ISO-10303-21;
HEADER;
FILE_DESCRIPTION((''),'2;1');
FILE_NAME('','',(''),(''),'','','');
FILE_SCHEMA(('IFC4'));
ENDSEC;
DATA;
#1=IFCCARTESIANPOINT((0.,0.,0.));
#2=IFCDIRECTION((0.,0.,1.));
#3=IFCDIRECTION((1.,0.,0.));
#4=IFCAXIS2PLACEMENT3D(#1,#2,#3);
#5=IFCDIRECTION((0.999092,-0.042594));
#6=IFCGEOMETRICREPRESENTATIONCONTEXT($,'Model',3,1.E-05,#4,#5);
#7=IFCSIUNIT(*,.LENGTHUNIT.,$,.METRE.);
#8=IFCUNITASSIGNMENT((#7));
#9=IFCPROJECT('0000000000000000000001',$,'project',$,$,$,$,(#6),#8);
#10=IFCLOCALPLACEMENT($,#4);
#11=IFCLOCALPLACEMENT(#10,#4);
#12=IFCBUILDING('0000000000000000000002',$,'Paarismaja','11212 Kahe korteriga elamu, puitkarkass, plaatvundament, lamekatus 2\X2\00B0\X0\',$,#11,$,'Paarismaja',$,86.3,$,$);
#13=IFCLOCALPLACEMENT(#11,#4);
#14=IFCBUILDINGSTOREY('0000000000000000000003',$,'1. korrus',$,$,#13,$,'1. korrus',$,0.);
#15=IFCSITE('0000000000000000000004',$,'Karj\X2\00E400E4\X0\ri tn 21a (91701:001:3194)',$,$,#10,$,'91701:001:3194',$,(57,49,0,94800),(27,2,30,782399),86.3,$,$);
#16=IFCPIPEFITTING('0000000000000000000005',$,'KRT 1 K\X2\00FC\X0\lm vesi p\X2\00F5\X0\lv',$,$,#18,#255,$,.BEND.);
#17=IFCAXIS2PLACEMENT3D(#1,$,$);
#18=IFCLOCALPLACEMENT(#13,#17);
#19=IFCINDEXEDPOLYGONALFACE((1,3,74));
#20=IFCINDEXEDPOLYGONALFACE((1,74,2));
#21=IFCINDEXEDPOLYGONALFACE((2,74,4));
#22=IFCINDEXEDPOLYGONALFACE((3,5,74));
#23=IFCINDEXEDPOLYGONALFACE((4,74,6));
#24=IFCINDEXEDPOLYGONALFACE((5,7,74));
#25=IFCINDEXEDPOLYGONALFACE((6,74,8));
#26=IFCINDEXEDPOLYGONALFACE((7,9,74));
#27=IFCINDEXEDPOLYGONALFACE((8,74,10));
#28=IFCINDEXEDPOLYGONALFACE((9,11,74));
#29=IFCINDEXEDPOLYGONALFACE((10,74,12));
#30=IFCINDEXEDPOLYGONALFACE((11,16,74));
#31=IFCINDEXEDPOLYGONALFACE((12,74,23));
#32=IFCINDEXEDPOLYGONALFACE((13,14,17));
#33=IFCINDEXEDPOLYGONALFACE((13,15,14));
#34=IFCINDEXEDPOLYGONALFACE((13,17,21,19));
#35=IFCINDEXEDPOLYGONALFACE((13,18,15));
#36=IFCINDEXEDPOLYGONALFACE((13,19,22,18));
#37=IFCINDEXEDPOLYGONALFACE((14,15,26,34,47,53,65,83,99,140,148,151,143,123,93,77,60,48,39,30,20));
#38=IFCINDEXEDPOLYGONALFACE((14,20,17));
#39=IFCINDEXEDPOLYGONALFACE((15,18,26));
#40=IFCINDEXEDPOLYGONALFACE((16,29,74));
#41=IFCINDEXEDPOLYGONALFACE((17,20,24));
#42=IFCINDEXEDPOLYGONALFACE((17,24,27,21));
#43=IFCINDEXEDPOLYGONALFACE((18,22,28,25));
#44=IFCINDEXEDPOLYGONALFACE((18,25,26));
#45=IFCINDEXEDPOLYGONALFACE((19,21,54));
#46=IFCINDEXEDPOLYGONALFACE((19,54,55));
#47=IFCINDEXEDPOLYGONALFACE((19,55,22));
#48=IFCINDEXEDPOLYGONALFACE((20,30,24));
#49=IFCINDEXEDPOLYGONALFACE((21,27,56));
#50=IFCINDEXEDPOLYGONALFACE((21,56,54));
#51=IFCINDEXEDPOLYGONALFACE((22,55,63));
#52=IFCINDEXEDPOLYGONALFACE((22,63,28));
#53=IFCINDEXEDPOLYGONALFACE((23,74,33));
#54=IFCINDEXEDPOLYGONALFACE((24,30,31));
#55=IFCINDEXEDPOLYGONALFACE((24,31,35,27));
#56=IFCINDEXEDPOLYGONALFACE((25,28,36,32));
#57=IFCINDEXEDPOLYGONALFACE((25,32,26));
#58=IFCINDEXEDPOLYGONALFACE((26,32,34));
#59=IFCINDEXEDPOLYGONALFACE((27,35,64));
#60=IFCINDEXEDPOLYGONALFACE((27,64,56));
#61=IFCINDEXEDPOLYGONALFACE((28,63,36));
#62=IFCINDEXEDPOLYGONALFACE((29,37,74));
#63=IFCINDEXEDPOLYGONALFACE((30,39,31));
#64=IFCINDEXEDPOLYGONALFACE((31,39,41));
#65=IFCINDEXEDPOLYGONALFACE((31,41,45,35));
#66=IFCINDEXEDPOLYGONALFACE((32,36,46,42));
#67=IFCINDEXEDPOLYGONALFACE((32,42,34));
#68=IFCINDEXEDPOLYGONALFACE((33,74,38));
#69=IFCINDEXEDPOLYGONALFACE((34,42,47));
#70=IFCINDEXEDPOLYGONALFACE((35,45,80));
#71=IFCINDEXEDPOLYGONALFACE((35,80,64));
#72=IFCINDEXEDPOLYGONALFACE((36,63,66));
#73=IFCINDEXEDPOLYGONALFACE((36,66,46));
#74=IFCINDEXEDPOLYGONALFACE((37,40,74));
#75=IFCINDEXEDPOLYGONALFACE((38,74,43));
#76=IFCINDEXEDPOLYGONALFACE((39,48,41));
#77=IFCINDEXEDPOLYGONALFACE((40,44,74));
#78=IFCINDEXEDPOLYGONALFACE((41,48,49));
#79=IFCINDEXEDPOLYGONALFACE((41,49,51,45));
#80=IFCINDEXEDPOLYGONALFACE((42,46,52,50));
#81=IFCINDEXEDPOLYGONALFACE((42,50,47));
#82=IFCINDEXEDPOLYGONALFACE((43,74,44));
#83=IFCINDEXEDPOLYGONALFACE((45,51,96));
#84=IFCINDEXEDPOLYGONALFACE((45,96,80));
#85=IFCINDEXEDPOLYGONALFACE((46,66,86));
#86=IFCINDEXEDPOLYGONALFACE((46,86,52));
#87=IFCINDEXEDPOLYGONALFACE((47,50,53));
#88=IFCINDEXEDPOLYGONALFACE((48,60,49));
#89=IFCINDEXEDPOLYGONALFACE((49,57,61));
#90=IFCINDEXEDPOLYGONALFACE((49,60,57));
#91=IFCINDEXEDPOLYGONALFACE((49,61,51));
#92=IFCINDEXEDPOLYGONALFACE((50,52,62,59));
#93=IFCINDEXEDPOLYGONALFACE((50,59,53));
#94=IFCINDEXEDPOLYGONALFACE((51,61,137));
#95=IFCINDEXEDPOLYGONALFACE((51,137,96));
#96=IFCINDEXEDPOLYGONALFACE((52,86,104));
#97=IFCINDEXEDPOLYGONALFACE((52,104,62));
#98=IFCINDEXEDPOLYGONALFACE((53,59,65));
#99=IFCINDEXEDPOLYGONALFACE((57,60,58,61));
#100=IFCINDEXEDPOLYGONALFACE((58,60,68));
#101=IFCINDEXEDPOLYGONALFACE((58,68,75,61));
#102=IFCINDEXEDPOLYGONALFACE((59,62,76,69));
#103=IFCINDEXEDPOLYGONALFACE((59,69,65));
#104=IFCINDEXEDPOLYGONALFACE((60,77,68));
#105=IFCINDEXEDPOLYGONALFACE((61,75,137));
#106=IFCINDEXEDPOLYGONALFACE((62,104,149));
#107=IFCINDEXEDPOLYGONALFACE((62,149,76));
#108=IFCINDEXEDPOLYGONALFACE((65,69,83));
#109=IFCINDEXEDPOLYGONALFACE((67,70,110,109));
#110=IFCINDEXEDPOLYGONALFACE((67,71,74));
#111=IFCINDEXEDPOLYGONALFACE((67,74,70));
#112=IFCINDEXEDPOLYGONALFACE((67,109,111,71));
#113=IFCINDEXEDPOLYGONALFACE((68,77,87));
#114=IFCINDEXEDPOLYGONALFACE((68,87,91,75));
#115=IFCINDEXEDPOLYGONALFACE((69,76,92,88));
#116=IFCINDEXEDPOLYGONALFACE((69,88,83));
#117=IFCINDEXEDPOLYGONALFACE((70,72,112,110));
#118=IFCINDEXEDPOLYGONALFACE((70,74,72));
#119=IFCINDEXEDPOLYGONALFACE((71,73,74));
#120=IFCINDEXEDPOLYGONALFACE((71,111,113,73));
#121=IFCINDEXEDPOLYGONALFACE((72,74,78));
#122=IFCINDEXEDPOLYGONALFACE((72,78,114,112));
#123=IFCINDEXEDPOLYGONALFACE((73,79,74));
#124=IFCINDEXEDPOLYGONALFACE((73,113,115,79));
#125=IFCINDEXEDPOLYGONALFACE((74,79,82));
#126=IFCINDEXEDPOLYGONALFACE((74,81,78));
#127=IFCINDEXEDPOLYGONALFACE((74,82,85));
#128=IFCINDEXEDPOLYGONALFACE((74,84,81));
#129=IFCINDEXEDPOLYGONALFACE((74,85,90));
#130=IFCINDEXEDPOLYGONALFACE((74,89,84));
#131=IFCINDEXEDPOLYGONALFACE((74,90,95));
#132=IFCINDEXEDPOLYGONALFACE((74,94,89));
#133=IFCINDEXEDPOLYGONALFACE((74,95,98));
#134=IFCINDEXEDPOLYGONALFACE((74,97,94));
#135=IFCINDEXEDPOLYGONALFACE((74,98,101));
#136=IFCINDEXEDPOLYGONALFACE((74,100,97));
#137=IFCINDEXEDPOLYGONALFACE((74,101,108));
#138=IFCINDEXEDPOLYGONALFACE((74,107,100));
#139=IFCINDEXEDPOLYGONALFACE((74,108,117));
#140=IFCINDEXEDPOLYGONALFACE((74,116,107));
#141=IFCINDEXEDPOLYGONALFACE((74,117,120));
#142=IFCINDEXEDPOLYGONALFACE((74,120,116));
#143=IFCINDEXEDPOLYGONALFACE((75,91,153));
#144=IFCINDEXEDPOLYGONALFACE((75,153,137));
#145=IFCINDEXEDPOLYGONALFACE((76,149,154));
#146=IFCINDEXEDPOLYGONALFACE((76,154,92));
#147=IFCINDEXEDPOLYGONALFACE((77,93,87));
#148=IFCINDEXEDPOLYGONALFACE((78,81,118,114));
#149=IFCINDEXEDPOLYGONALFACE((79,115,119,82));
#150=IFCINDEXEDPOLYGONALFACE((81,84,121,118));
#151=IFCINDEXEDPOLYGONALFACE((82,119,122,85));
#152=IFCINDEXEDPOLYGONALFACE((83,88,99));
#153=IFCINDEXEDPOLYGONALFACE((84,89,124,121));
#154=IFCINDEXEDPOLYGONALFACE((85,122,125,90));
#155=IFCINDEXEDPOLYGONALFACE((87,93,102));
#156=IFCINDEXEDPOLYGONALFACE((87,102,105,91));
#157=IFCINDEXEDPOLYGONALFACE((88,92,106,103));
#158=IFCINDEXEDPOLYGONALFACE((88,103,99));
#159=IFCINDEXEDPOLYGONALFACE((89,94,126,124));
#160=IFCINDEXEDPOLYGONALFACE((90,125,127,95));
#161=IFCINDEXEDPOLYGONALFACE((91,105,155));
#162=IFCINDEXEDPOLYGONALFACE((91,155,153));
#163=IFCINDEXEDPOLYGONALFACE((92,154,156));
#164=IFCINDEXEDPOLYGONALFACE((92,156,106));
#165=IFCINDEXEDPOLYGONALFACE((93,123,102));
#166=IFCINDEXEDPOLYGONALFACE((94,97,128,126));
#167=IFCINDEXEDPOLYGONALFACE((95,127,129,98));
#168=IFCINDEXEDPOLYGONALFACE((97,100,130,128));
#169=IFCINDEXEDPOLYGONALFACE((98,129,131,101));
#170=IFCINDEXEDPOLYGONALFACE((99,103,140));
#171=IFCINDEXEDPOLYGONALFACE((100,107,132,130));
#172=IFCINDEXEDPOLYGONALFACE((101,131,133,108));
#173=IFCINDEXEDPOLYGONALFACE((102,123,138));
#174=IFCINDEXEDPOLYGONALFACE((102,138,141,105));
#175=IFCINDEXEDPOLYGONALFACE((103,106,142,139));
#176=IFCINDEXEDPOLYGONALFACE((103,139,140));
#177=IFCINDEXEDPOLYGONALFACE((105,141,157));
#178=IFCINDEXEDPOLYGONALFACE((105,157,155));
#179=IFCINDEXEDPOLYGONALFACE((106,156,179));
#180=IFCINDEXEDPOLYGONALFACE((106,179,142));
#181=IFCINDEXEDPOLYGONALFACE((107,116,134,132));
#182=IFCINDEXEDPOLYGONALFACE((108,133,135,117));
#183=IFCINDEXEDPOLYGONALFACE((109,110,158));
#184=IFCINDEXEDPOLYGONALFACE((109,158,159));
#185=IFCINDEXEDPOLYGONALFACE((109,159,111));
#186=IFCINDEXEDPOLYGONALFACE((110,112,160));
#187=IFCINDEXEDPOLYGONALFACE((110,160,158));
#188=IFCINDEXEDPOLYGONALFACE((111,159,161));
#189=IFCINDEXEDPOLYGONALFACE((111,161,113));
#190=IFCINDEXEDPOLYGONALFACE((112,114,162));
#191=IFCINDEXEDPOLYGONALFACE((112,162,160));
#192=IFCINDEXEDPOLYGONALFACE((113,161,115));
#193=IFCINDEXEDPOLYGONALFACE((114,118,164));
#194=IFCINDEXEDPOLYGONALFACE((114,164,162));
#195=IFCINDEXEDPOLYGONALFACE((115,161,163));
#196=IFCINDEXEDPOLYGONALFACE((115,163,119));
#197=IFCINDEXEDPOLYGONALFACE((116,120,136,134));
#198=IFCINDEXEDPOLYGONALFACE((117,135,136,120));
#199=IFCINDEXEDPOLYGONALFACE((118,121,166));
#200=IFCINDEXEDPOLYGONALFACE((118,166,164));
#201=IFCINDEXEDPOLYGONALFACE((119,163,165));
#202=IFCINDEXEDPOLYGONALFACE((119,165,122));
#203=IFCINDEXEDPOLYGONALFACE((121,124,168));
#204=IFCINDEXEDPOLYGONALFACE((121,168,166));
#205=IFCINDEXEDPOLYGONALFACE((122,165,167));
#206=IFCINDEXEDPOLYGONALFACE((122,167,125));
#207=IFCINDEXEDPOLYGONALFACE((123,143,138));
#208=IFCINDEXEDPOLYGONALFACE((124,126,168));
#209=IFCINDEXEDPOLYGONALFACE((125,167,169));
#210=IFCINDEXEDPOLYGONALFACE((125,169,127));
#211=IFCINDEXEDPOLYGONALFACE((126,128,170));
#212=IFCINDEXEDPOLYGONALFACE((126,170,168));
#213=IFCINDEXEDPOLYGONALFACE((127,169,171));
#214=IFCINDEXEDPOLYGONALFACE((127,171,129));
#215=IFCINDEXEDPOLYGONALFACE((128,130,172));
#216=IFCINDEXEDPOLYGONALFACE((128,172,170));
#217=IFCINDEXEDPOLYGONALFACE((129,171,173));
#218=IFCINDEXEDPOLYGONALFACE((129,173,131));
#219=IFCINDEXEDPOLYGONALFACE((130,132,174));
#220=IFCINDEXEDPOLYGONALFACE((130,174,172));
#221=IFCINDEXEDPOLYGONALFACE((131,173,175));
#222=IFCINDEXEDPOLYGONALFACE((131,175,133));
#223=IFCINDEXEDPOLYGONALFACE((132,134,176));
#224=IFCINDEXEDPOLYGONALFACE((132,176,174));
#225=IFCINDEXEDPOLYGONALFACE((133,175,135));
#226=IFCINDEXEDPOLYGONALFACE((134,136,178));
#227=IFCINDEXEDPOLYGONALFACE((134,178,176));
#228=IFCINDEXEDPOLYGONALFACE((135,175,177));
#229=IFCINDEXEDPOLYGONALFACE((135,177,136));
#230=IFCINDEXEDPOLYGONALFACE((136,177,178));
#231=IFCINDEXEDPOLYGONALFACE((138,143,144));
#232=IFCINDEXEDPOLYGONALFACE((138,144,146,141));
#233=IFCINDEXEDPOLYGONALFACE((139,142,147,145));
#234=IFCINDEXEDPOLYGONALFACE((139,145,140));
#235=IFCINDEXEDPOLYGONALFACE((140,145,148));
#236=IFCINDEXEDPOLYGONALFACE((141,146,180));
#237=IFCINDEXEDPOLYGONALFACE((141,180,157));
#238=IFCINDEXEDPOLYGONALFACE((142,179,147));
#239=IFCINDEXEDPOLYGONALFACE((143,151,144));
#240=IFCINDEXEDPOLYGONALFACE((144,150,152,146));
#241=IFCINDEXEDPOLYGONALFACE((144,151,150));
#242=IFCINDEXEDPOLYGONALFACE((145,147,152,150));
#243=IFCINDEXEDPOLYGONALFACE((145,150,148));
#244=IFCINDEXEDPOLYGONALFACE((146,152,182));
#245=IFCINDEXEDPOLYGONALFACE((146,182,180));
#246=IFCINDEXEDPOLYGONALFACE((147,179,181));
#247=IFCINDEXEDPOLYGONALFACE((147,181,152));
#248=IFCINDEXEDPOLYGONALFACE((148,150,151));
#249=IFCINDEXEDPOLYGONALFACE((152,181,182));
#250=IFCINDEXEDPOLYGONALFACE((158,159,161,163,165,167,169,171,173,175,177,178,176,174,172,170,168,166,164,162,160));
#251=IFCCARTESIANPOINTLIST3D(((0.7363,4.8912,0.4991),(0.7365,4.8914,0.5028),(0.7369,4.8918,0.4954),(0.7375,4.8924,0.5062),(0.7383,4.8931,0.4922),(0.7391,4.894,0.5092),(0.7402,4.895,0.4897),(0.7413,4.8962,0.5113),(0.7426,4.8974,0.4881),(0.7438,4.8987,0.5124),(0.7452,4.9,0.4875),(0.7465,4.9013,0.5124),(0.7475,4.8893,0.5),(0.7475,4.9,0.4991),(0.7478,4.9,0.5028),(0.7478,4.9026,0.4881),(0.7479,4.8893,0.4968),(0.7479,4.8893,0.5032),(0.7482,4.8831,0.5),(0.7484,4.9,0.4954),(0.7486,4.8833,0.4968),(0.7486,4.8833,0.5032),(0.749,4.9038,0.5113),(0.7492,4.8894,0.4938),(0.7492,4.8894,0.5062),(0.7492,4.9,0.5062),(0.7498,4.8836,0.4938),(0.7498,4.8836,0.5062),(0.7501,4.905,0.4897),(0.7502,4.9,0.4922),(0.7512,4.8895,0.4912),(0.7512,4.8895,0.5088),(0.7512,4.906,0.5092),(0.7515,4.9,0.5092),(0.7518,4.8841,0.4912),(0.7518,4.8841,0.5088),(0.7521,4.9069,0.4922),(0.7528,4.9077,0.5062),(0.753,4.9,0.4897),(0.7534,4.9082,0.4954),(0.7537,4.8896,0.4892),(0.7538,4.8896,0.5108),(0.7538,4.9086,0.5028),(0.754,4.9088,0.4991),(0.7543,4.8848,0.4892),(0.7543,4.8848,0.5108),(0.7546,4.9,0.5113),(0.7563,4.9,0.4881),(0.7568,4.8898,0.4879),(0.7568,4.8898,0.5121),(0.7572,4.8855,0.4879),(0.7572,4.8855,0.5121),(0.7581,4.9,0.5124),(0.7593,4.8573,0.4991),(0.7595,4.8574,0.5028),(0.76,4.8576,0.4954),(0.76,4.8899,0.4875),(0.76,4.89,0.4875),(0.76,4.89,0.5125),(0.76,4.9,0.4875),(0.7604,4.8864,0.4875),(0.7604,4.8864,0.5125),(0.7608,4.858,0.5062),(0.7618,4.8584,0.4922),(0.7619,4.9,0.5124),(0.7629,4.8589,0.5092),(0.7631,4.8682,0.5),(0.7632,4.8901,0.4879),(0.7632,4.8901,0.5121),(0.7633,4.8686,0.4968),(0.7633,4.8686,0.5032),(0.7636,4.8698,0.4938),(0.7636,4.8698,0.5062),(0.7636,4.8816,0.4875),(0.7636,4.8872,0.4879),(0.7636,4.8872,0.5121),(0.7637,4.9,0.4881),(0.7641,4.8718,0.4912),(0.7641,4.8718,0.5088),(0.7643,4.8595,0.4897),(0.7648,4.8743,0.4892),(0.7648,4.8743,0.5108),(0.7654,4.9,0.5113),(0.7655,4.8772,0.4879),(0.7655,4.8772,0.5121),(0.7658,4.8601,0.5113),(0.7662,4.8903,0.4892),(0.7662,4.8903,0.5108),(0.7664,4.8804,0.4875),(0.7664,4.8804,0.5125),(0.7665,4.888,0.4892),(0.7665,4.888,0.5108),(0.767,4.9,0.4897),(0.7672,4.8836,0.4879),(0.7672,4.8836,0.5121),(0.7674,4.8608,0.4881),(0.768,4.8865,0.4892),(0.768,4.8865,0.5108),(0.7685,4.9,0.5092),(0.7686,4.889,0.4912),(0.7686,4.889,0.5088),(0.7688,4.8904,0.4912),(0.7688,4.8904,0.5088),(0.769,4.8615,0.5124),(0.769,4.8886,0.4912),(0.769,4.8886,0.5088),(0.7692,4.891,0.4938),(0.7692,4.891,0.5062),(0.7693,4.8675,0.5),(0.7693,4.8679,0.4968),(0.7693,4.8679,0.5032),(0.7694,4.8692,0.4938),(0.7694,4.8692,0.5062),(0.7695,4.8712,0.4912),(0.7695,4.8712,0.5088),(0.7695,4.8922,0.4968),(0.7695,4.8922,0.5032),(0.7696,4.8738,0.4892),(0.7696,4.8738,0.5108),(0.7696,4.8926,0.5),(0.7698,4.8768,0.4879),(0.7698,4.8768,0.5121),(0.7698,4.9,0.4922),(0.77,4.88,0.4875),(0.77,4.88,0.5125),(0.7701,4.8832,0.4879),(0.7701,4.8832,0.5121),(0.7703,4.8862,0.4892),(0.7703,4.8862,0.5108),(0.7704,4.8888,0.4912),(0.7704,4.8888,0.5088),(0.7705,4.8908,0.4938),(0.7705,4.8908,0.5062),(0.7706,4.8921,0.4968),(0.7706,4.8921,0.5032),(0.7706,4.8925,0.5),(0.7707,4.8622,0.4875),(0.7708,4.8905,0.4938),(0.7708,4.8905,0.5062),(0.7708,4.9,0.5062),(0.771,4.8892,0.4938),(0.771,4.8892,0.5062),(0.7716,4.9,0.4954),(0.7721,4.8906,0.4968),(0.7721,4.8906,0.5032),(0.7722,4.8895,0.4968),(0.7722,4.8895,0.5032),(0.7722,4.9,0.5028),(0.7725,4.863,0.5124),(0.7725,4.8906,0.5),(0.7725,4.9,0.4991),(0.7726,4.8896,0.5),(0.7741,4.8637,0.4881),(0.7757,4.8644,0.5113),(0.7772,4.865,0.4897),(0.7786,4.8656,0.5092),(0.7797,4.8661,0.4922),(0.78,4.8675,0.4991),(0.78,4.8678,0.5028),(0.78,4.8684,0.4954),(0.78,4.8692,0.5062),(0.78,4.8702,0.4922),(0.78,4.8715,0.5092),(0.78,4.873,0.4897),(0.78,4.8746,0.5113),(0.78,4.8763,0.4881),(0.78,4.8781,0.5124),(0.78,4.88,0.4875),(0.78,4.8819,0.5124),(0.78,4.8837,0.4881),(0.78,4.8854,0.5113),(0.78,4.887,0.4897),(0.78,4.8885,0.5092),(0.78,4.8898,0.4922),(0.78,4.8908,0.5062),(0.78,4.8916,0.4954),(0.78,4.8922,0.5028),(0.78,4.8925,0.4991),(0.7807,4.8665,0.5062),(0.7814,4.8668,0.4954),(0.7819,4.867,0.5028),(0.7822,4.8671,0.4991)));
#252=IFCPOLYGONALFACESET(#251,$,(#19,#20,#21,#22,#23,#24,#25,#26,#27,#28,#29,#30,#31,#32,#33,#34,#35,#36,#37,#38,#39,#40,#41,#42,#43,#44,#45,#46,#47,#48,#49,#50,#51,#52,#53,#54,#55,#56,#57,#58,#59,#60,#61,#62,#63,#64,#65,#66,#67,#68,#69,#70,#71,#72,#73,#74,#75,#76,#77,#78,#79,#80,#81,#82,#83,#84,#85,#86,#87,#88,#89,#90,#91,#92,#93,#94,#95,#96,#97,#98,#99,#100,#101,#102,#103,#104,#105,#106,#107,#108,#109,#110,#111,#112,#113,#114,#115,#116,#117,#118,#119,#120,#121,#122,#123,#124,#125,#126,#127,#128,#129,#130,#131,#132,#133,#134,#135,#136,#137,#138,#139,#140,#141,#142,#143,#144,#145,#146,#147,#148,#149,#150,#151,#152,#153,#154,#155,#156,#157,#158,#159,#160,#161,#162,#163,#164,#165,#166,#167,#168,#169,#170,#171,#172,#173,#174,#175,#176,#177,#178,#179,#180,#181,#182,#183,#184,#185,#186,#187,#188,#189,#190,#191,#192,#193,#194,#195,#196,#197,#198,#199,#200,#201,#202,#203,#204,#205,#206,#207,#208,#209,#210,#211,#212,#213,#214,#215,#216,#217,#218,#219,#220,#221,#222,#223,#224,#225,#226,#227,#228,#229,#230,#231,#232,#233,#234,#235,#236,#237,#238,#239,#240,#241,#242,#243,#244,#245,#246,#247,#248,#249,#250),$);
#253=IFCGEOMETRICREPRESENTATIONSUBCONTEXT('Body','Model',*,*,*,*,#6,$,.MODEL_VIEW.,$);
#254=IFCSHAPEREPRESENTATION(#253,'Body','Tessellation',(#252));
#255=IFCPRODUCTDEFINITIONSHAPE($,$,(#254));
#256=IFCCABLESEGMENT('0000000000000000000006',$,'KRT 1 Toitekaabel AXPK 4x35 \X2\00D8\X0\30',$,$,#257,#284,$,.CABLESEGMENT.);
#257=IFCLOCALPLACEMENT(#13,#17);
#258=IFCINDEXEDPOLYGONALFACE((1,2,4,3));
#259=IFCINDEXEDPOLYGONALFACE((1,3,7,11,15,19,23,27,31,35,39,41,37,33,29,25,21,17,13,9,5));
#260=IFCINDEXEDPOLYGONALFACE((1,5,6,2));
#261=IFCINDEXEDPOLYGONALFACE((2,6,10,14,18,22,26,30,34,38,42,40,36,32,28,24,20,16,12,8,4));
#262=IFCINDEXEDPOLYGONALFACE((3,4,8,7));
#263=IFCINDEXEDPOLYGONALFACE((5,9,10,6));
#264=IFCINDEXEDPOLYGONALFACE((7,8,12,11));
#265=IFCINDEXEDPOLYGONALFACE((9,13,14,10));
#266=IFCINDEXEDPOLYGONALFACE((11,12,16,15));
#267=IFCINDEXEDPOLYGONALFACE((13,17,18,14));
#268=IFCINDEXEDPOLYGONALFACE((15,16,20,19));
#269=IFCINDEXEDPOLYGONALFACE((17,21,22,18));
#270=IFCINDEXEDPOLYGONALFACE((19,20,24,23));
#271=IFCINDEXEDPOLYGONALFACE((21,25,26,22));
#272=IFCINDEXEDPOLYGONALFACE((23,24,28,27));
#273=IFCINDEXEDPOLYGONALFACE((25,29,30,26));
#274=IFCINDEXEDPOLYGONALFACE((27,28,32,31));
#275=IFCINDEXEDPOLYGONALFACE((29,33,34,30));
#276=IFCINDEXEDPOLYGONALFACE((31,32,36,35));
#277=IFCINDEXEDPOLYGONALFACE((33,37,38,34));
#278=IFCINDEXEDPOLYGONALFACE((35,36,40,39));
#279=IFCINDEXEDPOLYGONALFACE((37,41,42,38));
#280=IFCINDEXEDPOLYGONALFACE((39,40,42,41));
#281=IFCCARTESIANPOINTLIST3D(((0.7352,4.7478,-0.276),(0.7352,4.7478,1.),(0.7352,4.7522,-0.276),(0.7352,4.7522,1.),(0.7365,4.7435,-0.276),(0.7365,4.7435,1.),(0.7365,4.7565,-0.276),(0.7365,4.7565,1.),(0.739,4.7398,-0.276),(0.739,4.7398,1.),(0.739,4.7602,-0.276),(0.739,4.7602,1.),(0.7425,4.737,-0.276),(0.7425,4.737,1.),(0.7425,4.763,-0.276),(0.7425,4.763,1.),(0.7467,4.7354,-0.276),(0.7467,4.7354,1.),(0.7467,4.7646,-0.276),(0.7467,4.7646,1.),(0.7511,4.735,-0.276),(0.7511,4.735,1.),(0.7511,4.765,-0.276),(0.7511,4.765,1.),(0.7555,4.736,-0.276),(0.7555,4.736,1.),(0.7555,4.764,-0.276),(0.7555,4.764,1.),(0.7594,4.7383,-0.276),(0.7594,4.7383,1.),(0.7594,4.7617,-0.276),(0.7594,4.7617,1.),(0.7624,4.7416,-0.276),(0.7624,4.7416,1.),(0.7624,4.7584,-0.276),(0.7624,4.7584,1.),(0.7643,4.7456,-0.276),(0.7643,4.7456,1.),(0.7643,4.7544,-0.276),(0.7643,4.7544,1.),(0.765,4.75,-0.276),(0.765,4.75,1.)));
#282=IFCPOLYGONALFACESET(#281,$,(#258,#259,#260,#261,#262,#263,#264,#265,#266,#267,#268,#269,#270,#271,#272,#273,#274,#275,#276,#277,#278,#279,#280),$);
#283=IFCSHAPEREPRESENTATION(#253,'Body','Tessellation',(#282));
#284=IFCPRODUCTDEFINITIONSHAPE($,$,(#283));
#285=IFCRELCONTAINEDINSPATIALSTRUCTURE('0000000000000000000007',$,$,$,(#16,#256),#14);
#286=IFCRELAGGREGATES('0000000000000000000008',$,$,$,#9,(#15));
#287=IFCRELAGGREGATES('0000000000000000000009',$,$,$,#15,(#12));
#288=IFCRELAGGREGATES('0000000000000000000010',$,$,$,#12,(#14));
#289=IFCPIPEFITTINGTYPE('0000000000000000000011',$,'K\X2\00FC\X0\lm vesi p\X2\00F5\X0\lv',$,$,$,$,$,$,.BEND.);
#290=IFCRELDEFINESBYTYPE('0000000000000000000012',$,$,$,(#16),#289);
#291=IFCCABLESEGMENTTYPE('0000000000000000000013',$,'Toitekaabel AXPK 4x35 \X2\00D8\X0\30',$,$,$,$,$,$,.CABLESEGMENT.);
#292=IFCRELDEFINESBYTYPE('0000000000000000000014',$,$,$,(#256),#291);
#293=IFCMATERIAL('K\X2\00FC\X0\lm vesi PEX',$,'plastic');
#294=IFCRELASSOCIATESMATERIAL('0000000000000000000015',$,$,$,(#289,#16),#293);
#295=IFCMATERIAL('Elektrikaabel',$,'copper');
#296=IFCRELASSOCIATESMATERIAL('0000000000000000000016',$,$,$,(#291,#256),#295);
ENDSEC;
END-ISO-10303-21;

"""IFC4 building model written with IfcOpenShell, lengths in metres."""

from ifc_helpers import new_model, entity, si_unit, direction, frame, origin_with_axes, place, context, subcontext, project, spatial, circle, extrude, material, type_object, element, save


model = new_model("IFC4")

# Units and contexts
model_context = context("Model", 3, precision=1e-05, world=origin_with_axes(), true_north=direction((0.999092, -0.042594)))
body_context = subcontext(model_context, "Body", "Model", "MODEL_VIEW")
ifc_project = project(units=[si_unit("LENGTHUNIT", "METRE")], contexts=[model_context])

# Site, building, storey
site_placement = place(None, origin_with_axes())
site = spatial("IfcSite", under=ifc_project, at=site_placement, Name="Karjääri tn 21a (91701:001:3194)", LongName="91701:001:3194", RefLatitude=(57, 49, 0, 94800), RefLongitude=(27, 2, 30, 782399), RefElevation=86.3)
building_placement = place(site_placement, origin_with_axes())
building = spatial("IfcBuilding", under=site, at=building_placement, Name="Paarismaja", Description="11212 Kahe korteriga elamu, puitkarkass, plaatvundament, lamekatus 2°", LongName="Paarismaja", ElevationOfRefHeight=86.3)
storey_placement = place(building_placement, origin_with_axes())
storey = spatial("IfcBuildingStorey", under=building, at=storey_placement, Name="1. korrus", LongName="1. korrus", Elevation=0.0)

# Shared definitions
ifc_material_1 = material(Name="Elektrikaabel", Category="copper")

# Pipe fitting
ifc_material_2 = material(Name="Külm vesi PEX", Category="plastic")
pipe_fitting_type_1 = type_object("IfcPipeFittingType", Name="Külm vesi põlv", PredefinedType="BEND", material=ifc_material_2)
pipe_fitting_1_placement = place(storey_placement, frame((0.76, 4.88, 0.5), z_axis=(0.0, 0.0, 1.0), x_axis=(1.0, 0.0, 0.0)))
element("IfcPipeFitting", 1, at=pipe_fitting_1_placement, inside=storey, type_object=pipe_fitting_type_1, material=ifc_material_2, Name="KRT 1 Külm vesi põlv", PredefinedType="BEND", context=body_context, shape_type="AdvancedSweptSolid", body=[
    entity("IfcSweptDiskSolid", entity("IfcIndexedPolyCurve", entity("IfcCartesianPointList3D", [[0.02, 0.0, 0.0], [0.01, 0.0, 0.0], [0.0064, 0.0004, 0.0], [0.0036, 0.0016, 0.0], [0.0016, 0.0036, 0.0], [0.0004, 0.0064, 0.0], [0.0, 0.01, 0.0], [0.0, 0.02, 0.0]]), None, False), 0.0125),
])

# Cable segment
cable_segment_type = type_object("IfcCableSegmentType", Name="Toitekaabel AXPK 4x35 Ø30", PredefinedType="CABLESEGMENT", material=ifc_material_1)
cable_segment_placement = place(storey_placement, frame((0.75, 4.75, -0.276), z_axis=(0.0, 0.0, 1.0), x_axis=(1.0, 0.0, 0.0)))
element("IfcCableSegment", 2, at=cable_segment_placement, inside=storey, type_object=cable_segment_type, material=ifc_material_1, Name="KRT 1 Toitekaabel AXPK 4x35 Ø30", PredefinedType="CABLESEGMENT", context=body_context, shape_type="SweptSolid", body=[
    extrude(circle(Radius=0.015), origin_with_axes(), (0.0, 0.0, 1.0), 1.276),
])

save(model, "model.ifc")
